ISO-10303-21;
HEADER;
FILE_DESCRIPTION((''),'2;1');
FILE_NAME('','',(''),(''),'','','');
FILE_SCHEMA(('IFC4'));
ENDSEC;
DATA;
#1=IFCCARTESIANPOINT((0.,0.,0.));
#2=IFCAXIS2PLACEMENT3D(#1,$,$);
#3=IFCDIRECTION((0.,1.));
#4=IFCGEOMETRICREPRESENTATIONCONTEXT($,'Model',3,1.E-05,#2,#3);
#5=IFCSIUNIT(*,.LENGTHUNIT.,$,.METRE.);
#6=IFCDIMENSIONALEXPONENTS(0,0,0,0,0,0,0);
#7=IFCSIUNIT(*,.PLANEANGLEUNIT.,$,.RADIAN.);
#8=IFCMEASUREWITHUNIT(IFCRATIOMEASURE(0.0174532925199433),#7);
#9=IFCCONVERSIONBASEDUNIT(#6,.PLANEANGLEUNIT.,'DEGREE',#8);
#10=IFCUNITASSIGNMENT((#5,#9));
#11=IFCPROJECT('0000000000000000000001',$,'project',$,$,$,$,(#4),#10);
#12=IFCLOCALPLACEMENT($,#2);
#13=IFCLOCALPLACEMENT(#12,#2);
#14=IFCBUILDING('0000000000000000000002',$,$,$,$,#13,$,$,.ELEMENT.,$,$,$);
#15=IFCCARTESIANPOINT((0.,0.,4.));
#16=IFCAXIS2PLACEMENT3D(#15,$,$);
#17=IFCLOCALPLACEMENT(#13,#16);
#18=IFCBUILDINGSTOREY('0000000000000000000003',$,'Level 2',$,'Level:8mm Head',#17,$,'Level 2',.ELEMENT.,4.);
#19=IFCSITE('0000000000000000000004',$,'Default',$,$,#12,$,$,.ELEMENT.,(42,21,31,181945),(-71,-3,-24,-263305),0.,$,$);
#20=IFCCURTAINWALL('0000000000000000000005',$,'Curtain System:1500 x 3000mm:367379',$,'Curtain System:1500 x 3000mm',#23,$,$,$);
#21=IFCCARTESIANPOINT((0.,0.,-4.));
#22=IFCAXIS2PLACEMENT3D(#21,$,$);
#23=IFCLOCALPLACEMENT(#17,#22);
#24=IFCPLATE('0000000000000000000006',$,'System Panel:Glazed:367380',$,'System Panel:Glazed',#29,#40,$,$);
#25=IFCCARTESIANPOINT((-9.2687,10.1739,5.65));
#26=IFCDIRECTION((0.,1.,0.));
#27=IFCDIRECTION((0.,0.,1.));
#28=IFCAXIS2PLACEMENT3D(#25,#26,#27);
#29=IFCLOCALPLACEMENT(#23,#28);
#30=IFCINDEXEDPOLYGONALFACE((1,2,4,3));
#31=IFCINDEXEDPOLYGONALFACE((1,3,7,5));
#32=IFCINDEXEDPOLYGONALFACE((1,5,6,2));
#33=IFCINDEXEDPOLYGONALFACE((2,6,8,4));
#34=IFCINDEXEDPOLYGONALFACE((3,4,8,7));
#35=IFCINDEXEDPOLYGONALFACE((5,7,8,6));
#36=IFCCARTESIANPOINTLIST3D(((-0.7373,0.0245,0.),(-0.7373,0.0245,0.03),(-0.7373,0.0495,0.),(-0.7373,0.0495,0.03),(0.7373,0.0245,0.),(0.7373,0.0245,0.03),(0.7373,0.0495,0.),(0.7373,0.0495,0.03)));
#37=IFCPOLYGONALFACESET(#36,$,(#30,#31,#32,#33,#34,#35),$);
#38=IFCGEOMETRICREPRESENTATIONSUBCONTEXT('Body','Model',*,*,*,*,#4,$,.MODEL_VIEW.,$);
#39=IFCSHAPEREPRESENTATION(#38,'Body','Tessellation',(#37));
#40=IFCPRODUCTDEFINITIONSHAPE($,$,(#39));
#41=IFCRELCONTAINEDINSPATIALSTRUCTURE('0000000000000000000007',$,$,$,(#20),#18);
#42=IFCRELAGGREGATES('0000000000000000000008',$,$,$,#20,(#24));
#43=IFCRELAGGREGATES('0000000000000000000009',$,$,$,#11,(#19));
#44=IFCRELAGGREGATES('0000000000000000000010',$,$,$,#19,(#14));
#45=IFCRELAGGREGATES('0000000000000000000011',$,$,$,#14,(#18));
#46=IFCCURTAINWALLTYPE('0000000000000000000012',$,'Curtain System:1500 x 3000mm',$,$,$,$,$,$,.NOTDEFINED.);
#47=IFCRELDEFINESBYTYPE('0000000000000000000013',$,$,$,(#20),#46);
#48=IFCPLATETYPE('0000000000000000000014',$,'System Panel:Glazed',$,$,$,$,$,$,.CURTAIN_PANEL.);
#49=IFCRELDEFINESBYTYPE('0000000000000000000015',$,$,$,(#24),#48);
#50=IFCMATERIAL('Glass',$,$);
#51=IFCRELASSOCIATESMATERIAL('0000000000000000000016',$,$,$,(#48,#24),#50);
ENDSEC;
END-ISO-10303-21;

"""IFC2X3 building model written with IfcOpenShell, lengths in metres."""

from ifc_helpers import new_model, entity, si_unit, converted_unit, direction, frame, origin, origin_2d_with_axis, place, context, subcontext, project, spatial, rectangle, extrude, source, transform, mapped, material, type_object, type_shapes, element, aggregate, save


model = new_model("IFC2X3")

# Units and contexts
model_context = context("Model", 3, precision=1e-05, world=origin(), true_north=direction((0.0, 1.0)))
body_context = subcontext(model_context, "Body", "Model", "MODEL_VIEW")
ifc_project = project(units=[si_unit("LENGTHUNIT", "METRE"), converted_unit("PLANEANGLEUNIT", "DEGREE", entity("IfcRatioMeasure", 0.0174532925199433), si_unit("PLANEANGLEUNIT", "RADIAN"), dimensions=[0, 0, 0, 0, 0, 0, 0])], contexts=[model_context])

# Site, building, storey
site_placement = place(None, origin())
site = spatial("IfcSite", under=ifc_project, at=site_placement, Name="Default", CompositionType="ELEMENT", RefLatitude=(42, 21, 31, 181945), RefLongitude=(-71, -3, -24, -263305), RefElevation=0.0)
building_placement = place(site_placement, origin())
building = spatial("IfcBuilding", under=site, at=building_placement, CompositionType="ELEMENT")
storey_placement = place(building_placement, frame((0.0, 0.0, 4.0)))
storey = spatial("IfcBuildingStorey", under=building, at=storey_placement, Name="Level 2", ObjectType="Level:8mm Head", LongName="Level 2", CompositionType="ELEMENT", Elevation=4.0)

# Curtain wall, plate
curtain_wall_type = type_object("IfcCurtainWallType", Name="Curtain System:1500 x 3000mm", PredefinedType="NOTDEFINED")
curtain_wall_1_placement = place(storey_placement, frame((0.0, 0.0, -4.0)))
curtain_wall_1 = element("IfcCurtainWall", 1, at=curtain_wall_1_placement, inside=storey, type_object=curtain_wall_type, Name="Curtain System:1500 x 3000mm:367379", ObjectType="Curtain System:1500 x 3000mm")
ifc_material_1 = material(Name="Glass")
plate_type_1 = type_object("IfcPlateType", Name="System Panel:Glazed", PredefinedType="CURTAIN_PANEL", material=ifc_material_1)
shared_shape_1 = source(origin(), body_context, "Body", "SweptSolid", [
    extrude(rectangle(XDim=0.025, YDim=1.4746, at=origin_2d_with_axis()), frame((0.0, 0.037, 0.0), z_axis=(0.0, 0.0, 1.0), x_axis=(0.0, 1.0, 0.0)), (0.0, 0.0, 1.0), 0.03),
])
type_shapes(plate_type_1, [shared_shape_1])
plate_1_placement = place(curtain_wall_1_placement, frame((-9.2687, 10.1739, 5.65), z_axis=(0.0, 1.0, 0.0), x_axis=(0.0, 0.0, 1.0)))
plate_1 = element("IfcPlate", 2, at=plate_1_placement, type_object=plate_type_1, material=ifc_material_1, Name="System Panel:Glazed:367380", ObjectType="System Panel:Glazed", context=body_context, shape_type="MappedRepresentation", body=[
    mapped(shared_shape_1, transform((0.0, 0.0, 0.0), scale=1.0)),
])
aggregate(curtain_wall_1, [plate_1])

save(model, "model.ifc")
